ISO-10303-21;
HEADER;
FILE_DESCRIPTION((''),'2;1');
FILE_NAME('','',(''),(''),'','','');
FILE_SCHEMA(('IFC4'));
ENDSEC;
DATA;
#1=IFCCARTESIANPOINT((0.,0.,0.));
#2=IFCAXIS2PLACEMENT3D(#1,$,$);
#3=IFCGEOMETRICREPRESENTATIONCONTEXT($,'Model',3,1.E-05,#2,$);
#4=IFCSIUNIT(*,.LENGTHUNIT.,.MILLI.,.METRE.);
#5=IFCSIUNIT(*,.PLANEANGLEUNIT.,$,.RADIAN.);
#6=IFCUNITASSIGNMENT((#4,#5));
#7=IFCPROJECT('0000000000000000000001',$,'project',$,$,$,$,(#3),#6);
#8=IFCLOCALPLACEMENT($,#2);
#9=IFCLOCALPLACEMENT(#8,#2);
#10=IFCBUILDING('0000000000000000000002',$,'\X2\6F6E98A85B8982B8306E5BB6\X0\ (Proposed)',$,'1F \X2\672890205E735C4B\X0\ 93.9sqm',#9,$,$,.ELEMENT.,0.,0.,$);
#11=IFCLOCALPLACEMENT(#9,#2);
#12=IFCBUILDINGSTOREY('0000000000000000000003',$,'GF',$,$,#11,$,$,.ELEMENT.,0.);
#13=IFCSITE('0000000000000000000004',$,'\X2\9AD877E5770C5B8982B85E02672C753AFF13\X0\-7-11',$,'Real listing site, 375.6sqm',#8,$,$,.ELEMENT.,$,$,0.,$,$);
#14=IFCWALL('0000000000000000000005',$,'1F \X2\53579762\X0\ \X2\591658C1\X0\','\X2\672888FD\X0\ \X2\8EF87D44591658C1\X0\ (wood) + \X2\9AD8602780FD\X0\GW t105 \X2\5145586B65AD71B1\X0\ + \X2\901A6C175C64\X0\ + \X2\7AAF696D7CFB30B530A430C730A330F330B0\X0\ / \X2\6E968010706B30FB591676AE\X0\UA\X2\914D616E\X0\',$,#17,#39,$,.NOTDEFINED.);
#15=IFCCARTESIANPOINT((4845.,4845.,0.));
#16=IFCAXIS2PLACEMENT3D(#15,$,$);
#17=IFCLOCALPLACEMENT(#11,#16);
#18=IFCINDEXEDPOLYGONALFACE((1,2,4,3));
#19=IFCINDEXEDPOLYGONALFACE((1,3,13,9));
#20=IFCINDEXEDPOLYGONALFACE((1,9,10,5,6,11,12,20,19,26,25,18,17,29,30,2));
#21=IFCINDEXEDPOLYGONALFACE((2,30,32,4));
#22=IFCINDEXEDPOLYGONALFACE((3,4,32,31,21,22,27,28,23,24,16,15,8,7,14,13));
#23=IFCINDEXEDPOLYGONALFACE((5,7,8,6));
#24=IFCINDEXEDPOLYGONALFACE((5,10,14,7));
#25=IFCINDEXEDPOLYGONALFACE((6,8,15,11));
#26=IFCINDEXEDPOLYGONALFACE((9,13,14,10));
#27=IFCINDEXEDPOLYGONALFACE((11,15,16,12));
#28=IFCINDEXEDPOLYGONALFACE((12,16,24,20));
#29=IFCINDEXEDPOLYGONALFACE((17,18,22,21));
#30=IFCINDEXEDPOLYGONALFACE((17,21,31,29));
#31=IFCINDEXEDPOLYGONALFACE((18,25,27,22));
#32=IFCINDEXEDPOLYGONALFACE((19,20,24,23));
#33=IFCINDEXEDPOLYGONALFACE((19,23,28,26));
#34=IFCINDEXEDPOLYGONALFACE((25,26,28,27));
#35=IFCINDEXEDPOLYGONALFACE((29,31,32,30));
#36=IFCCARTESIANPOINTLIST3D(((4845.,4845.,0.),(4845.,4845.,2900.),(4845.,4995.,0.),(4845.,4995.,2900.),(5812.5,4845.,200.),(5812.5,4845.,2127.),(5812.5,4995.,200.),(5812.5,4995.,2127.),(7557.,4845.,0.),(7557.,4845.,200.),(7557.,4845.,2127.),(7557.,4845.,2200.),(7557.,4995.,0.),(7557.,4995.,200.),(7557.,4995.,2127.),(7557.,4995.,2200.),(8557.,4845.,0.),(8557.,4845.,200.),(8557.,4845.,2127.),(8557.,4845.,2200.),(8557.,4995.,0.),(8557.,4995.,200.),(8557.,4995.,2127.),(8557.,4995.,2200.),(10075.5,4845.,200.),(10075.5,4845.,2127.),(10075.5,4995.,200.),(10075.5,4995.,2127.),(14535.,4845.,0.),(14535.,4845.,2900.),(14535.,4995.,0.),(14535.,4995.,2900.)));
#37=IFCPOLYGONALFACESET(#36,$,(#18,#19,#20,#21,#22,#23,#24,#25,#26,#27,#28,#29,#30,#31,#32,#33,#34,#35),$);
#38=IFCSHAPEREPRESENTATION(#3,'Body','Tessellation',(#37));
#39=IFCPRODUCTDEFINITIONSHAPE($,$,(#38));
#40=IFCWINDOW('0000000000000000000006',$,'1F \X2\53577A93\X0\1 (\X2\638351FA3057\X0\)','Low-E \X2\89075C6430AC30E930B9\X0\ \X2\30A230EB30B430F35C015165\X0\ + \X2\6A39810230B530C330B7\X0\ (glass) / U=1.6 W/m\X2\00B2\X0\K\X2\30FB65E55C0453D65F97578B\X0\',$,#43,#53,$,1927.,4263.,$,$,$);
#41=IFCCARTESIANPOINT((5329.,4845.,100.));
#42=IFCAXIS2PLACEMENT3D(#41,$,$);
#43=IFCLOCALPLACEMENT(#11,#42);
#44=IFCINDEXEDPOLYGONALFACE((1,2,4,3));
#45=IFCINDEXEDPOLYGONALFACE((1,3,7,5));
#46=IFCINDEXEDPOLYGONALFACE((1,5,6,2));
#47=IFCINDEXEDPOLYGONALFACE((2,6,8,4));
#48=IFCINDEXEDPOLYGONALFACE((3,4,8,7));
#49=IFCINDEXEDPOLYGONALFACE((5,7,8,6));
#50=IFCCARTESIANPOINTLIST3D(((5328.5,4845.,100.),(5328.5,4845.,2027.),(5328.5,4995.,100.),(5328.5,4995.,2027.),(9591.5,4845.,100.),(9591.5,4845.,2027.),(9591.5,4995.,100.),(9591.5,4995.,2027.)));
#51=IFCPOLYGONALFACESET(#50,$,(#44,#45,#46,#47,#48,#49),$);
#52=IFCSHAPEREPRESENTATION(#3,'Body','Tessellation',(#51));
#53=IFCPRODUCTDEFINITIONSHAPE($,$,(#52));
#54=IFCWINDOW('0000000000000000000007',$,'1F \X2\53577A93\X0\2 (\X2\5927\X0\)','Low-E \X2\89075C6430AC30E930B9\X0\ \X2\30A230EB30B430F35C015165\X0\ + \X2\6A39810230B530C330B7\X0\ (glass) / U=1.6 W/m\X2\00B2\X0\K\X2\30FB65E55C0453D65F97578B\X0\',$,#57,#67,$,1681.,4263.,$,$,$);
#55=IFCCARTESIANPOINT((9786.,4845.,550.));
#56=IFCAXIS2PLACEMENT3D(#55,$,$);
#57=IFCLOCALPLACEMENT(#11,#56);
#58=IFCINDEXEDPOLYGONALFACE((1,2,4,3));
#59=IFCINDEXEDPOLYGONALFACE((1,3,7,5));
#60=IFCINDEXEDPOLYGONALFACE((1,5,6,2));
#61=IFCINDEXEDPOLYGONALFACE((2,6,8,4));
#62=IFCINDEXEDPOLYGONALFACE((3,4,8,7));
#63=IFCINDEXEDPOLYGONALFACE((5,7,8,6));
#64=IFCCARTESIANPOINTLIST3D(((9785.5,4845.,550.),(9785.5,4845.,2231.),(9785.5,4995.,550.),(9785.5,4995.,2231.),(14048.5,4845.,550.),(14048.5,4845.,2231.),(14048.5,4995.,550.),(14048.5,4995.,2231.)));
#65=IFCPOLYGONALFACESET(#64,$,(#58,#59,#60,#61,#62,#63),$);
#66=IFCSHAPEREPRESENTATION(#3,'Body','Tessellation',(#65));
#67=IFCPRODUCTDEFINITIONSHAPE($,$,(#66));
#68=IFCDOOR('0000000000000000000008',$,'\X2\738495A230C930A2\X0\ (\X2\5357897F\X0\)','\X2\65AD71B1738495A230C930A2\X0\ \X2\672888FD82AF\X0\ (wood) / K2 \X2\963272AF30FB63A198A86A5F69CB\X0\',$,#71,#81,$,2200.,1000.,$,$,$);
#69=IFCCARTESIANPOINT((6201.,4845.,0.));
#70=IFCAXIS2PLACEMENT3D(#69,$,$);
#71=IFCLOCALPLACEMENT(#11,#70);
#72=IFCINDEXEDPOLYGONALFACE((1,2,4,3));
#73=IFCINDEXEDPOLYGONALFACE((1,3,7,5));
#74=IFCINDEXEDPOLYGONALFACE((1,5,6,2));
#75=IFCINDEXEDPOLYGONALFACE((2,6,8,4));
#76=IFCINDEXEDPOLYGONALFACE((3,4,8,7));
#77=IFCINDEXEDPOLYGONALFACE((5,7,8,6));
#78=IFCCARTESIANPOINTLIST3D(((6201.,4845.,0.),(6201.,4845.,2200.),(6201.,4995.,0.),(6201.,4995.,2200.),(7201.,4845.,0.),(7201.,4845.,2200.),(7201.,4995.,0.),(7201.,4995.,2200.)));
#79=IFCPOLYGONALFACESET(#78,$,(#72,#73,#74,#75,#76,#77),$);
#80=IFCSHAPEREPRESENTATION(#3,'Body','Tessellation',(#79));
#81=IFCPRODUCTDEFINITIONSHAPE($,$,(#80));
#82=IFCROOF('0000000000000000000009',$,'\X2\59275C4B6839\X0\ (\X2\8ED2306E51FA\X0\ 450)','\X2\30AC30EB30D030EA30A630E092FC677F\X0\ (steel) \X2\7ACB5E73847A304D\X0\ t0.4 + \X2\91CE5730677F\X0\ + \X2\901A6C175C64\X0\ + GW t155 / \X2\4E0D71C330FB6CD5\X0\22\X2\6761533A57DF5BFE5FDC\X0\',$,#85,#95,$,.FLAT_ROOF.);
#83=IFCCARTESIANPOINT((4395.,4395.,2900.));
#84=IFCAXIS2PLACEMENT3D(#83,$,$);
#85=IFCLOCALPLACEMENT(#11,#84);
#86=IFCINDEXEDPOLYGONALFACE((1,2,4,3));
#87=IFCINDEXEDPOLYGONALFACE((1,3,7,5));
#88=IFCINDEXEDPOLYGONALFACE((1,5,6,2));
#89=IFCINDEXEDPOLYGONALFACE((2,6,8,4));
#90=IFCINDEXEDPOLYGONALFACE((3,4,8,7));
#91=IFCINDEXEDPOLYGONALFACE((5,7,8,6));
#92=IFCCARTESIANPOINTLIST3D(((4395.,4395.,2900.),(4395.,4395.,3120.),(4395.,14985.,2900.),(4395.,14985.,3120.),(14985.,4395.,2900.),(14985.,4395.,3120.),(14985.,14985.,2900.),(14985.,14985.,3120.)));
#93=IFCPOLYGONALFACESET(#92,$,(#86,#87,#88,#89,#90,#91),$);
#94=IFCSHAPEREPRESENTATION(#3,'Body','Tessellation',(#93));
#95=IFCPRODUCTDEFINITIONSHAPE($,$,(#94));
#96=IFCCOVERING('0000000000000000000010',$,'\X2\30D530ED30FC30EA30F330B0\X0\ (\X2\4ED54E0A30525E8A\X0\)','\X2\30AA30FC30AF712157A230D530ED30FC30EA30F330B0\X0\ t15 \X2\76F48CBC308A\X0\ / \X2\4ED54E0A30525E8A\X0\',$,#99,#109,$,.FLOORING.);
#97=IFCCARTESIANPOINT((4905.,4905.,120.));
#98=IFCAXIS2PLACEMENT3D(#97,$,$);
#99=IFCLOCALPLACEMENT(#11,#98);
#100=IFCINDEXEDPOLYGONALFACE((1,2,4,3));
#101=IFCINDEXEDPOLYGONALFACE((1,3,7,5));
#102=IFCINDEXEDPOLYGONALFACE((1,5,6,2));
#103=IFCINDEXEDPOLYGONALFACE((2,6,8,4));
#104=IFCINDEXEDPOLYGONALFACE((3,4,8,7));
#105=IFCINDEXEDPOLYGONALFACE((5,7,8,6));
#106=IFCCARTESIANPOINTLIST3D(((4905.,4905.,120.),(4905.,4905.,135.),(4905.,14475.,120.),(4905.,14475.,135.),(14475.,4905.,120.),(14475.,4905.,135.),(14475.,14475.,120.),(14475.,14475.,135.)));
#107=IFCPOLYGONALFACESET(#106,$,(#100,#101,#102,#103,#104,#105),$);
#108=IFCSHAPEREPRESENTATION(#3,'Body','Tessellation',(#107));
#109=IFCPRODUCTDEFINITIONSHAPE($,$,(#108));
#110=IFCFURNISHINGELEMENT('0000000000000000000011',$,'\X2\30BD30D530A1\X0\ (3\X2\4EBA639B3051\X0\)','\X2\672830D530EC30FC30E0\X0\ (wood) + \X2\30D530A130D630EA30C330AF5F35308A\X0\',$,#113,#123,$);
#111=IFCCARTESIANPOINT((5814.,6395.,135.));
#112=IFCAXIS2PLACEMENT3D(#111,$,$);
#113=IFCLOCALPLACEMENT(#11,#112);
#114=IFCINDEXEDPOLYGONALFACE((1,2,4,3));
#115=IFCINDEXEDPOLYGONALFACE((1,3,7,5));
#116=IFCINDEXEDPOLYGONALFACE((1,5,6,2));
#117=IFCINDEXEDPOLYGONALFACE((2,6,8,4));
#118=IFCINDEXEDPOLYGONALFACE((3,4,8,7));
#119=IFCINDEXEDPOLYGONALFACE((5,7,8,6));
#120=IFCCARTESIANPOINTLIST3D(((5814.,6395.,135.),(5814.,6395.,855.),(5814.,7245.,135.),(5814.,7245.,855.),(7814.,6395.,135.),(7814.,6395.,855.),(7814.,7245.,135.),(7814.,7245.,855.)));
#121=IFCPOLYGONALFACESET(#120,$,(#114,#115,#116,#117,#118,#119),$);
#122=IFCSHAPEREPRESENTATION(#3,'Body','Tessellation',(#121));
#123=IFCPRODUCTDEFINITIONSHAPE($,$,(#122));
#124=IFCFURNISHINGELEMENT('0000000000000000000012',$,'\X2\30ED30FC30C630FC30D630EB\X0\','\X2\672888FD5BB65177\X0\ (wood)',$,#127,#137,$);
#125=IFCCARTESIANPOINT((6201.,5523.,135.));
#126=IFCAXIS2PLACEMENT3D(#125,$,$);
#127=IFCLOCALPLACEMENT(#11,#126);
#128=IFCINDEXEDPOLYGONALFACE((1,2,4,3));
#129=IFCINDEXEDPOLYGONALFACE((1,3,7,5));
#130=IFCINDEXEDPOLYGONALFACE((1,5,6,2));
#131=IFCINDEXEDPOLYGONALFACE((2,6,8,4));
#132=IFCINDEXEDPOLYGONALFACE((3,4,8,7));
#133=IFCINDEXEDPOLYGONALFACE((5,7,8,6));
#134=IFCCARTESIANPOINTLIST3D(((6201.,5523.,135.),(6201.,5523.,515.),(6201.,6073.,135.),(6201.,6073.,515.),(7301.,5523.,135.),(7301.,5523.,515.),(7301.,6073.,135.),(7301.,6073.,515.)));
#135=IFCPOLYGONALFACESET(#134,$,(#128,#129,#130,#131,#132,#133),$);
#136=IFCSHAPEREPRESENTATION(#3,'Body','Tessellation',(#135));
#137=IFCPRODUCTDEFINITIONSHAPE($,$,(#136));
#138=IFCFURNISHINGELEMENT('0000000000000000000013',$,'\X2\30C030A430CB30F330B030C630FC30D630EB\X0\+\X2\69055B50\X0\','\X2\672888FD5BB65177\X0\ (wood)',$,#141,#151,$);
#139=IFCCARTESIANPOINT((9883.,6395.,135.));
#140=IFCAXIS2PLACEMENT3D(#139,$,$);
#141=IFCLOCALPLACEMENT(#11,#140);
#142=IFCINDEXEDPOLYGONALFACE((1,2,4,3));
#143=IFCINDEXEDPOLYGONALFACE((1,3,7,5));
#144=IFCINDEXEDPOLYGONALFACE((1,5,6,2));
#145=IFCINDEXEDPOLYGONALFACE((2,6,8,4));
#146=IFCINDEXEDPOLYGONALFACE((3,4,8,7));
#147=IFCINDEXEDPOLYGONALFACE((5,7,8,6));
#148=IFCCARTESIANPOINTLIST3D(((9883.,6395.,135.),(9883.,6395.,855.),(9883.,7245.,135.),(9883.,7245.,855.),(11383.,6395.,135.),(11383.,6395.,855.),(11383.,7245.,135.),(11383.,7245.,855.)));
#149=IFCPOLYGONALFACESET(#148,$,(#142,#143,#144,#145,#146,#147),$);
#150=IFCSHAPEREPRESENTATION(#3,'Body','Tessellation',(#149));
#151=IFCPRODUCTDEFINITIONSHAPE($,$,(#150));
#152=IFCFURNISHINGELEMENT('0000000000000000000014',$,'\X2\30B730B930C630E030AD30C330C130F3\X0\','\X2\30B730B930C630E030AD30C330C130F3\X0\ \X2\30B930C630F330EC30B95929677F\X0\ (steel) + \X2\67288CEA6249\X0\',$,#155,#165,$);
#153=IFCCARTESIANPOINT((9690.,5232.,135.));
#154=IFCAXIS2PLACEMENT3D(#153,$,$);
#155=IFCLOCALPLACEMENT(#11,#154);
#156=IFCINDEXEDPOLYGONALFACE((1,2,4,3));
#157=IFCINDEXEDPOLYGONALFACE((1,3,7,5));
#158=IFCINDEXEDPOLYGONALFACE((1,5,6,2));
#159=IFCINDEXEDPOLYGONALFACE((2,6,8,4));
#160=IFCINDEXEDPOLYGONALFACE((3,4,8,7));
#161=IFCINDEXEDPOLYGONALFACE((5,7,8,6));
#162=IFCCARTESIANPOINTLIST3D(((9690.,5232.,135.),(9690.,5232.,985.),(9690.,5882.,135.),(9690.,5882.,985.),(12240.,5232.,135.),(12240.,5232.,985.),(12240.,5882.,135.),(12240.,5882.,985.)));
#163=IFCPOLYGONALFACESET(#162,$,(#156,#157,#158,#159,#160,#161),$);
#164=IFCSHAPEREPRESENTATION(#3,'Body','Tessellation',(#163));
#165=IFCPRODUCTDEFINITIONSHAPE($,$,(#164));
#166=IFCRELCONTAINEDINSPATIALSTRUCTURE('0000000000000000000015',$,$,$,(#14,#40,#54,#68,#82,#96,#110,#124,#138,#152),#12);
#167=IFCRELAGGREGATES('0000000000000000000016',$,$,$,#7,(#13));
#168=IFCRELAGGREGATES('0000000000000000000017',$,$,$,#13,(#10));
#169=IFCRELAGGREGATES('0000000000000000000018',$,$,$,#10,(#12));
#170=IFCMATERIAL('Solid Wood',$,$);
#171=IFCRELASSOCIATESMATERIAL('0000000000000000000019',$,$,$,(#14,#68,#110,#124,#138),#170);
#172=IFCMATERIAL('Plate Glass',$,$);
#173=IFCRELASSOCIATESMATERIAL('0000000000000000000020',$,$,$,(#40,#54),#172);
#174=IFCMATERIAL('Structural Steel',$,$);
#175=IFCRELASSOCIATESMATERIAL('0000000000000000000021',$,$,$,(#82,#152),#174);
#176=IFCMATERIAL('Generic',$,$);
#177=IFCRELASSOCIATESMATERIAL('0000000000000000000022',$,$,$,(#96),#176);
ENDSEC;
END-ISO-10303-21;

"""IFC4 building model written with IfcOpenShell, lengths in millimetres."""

from ifc_helpers import new_model, si_unit, frame, frame_2d, origin, place, context, project, spatial, rectangle, extrude, material, element, fill, save


model = new_model("IFC4")

# Units and contexts
model_context = context("Model", 3, precision=1e-05, world=origin())
ifc_project = project(units=[si_unit("LENGTHUNIT", "METRE", prefix="MILLI"), si_unit("PLANEANGLEUNIT", "RADIAN")], contexts=[model_context])

# Site, building, storey
site_placement = place(None, origin())
site = spatial("IfcSite", under=ifc_project, at=site_placement, Name="高知県安芸市本町３-7-11", ObjectType="Real listing site, 375.6sqm", CompositionType="ELEMENT", RefElevation=0.0)
building_placement = place(site_placement, origin())
building = spatial("IfcBuilding", under=site, at=building_placement, Name="潮風安芸の家 (Proposed)", ObjectType="1F 木造平屋 93.9sqm", CompositionType="ELEMENT", ElevationOfRefHeight=0.0, ElevationOfTerrain=0.0)
storey_placement = place(building_placement, origin())
storey = spatial("IfcBuildingStorey", under=building, at=storey_placement, Name="GF", CompositionType="ELEMENT", Elevation=0.0)

# Shared definitions
ifc_material_1 = material(Name="Solid Wood")

# Wall, openings, windows, door
wall_1_placement = place(storey_placement, frame((4845.0, 4845.0, 0.0)))
wall_1 = element("IfcWall", 1, at=wall_1_placement, inside=storey, material=ifc_material_1, Name="1F 南面 外壁", Description="木製 軸組外壁 (wood) + 高性能GW t105 充填断熱 + 通気層 + 窯業系サイディング / 準耐火・外皮UA配慮", PredefinedType="NOTDEFINED", context=model_context, shape_type="SweptSolid", body=[
    extrude(rectangle(XDim=9690.0, YDim=150.0, at=frame_2d((4845.0, 75.0))), frame((4845.0, 4845.0, 0.0)), (0.0, 0.0, 1.0), 2900.0),
])
opening_1_placement = place(storey_placement, frame((5329.0, 4845.0, 100.0)))
opening_1 = element("IfcOpeningElement", 2, at=opening_1_placement, cuts=wall_1, PredefinedType="NOTDEFINED", context=model_context, shape_type="SweptSolid", body=[
    extrude(rectangle(XDim=4263.0, YDim=150.0, at=frame_2d((2131.0, 75.0))), frame((5329.0, 4845.0, 100.0)), (0.0, 0.0, 1.0), 1927.0),
])
opening_2_placement = place(storey_placement, frame((9786.0, 4845.0, 550.0)))
opening_2 = element("IfcOpeningElement", 3, at=opening_2_placement, cuts=wall_1, PredefinedType="NOTDEFINED", context=model_context, shape_type="SweptSolid", body=[
    extrude(rectangle(XDim=4263.0, YDim=150.0, at=frame_2d((2131.0, 75.0))), frame((9786.0, 4845.0, 550.0)), (0.0, 0.0, 1.0), 1681.0),
])
opening_3_placement = place(storey_placement, frame((6201.0, 4845.0, 0.0)))
opening_3 = element("IfcOpeningElement", 4, at=opening_3_placement, cuts=wall_1, PredefinedType="NOTDEFINED", context=model_context, shape_type="SweptSolid", body=[
    extrude(rectangle(XDim=1000.0, YDim=150.0, at=frame_2d((500.0, 75.0))), frame((6201.0, 4845.0, 0.0)), (0.0, 0.0, 1.0), 2200.0),
])
ifc_material_2 = material(Name="Plate Glass")
window_1_placement = place(storey_placement, frame((5329.0, 4845.0, 100.0)))
window_1 = element("IfcWindow", 5, at=window_1_placement, inside=storey, material=ifc_material_2, Name="1F 南窓1 (掃出し)", Description="Low-E 複層ガラス アルゴン封入 + 樹脂サッシ (glass) / U=1.6 W/m²K・日射取得型", OverallHeight=1927.0, OverallWidth=4263.0, context=model_context, shape_type="SweptSolid", body=[
    extrude(rectangle(XDim=4263.0, YDim=150.0, at=frame_2d((2131.0, 75.0))), frame((5329.0, 4845.0, 100.0)), (0.0, 0.0, 1.0), 1927.0),
])
fill(opening_1, window_1)
window_2_placement = place(storey_placement, frame((9786.0, 4845.0, 550.0)))
window_2 = element("IfcWindow", 6, at=window_2_placement, inside=storey, material=ifc_material_2, Name="1F 南窓2 (大)", Description="Low-E 複層ガラス アルゴン封入 + 樹脂サッシ (glass) / U=1.6 W/m²K・日射取得型", OverallHeight=1681.0, OverallWidth=4263.0, context=model_context, shape_type="SweptSolid", body=[
    extrude(rectangle(XDim=4263.0, YDim=150.0, at=frame_2d((2131.0, 75.0))), frame((9786.0, 4845.0, 550.0)), (0.0, 0.0, 1.0), 1681.0),
])
fill(opening_2, window_2)
door_placement = place(storey_placement, frame((6201.0, 4845.0, 0.0)))
door = element("IfcDoor", 7, at=door_placement, inside=storey, material=ifc_material_1, Name="玄関ドア (南西)", Description="断熱玄関ドア 木製芯 (wood) / K2 防犯・採風機構", OverallHeight=2200.0, OverallWidth=1000.0, context=model_context, shape_type="SweptSolid", body=[
    extrude(rectangle(XDim=1000.0, YDim=150.0, at=frame_2d((500.0, 75.0))), frame((6201.0, 4845.0, 0.0)), (0.0, 0.0, 1.0), 2200.0),
])
fill(opening_3, door)

# Roof
ifc_material_3 = material(Name="Structural Steel")
roof_placement = place(storey_placement, frame((4395.0, 4395.0, 2900.0)))
element("IfcRoof", 8, at=roof_placement, inside=storey, material=ifc_material_3, Name="大屋根 (軒の出 450)", Description="ガルバリウム鋼板 (steel) 立平葺き t0.4 + 野地板 + 通気層 + GW t155 / 不燃・法22条区域対応", PredefinedType="FLAT_ROOF", context=model_context, shape_type="SweptSolid", body=[
    extrude(rectangle(XDim=10590.0, YDim=10590.0, at=frame_2d((5295.0, 5295.0))), frame((4395.0, 4395.0, 2900.0)), (0.0, 0.0, 1.0), 220.0),
])

# Covering
ifc_material_4 = material(Name="Generic")
covering_placement = place(storey_placement, frame((4905.0, 4905.0, 120.0)))
element("IfcCovering", 9, at=covering_placement, inside=storey, material=ifc_material_4, Name="フローリング (仕上げ床)", Description="オーク無垢フローリング t15 直貼り / 仕上げ床", PredefinedType="FLOORING", context=model_context, shape_type="SweptSolid", body=[
    extrude(rectangle(XDim=9570.0, YDim=9570.0, at=frame_2d((4785.0, 4785.0))), frame((4905.0, 4905.0, 120.0)), (0.0, 0.0, 1.0), 15.0),
])

# Furnishing elements
furnishing_1_placement = place(storey_placement, frame((5814.0, 6395.0, 135.0)))
element("IfcFurnishingElement", 10, at=furnishing_1_placement, inside=storey, material=ifc_material_1, Name="ソファ (3人掛け)", Description="木フレーム (wood) + ファブリック張り", context=model_context, shape_type="SweptSolid", body=[
    extrude(rectangle(XDim=2000.0, YDim=850.0, at=frame_2d((1000.0, 425.0))), frame((5814.0, 6395.0, 135.0)), (0.0, 0.0, 1.0), 720.0),
])
furnishing_2_placement = place(storey_placement, frame((6201.0, 5523.0, 135.0)))
element("IfcFurnishingElement", 11, at=furnishing_2_placement, inside=storey, material=ifc_material_1, Name="ローテーブル", Description="木製家具 (wood)", context=model_context, shape_type="SweptSolid", body=[
    extrude(rectangle(XDim=1100.0, YDim=550.0, at=frame_2d((550.0, 275.0))), frame((6201.0, 5523.0, 135.0)), (0.0, 0.0, 1.0), 380.0),
])
furnishing_3_placement = place(storey_placement, frame((9883.0, 6395.0, 135.0)))
element("IfcFurnishingElement", 12, at=furnishing_3_placement, inside=storey, material=ifc_material_1, Name="ダイニングテーブル+椅子", Description="木製家具 (wood)", context=model_context, shape_type="SweptSolid", body=[
    extrude(rectangle(XDim=1500.0, YDim=850.0, at=frame_2d((750.0, 425.0))), frame((9883.0, 6395.0, 135.0)), (0.0, 0.0, 1.0), 720.0),
])
furnishing_4_placement = place(storey_placement, frame((9690.0, 5232.0, 135.0)))
element("IfcFurnishingElement", 13, at=furnishing_4_placement, inside=storey, material=ifc_material_3, Name="システムキッチン", Description="システムキッチン ステンレス天板 (steel) + 木質扉", context=model_context, shape_type="SweptSolid", body=[
    extrude(rectangle(XDim=2550.0, YDim=650.0, at=frame_2d((1275.0, 325.0))), frame((9690.0, 5232.0, 135.0)), (0.0, 0.0, 1.0), 850.0),
])

save(model, "model.ifc")
